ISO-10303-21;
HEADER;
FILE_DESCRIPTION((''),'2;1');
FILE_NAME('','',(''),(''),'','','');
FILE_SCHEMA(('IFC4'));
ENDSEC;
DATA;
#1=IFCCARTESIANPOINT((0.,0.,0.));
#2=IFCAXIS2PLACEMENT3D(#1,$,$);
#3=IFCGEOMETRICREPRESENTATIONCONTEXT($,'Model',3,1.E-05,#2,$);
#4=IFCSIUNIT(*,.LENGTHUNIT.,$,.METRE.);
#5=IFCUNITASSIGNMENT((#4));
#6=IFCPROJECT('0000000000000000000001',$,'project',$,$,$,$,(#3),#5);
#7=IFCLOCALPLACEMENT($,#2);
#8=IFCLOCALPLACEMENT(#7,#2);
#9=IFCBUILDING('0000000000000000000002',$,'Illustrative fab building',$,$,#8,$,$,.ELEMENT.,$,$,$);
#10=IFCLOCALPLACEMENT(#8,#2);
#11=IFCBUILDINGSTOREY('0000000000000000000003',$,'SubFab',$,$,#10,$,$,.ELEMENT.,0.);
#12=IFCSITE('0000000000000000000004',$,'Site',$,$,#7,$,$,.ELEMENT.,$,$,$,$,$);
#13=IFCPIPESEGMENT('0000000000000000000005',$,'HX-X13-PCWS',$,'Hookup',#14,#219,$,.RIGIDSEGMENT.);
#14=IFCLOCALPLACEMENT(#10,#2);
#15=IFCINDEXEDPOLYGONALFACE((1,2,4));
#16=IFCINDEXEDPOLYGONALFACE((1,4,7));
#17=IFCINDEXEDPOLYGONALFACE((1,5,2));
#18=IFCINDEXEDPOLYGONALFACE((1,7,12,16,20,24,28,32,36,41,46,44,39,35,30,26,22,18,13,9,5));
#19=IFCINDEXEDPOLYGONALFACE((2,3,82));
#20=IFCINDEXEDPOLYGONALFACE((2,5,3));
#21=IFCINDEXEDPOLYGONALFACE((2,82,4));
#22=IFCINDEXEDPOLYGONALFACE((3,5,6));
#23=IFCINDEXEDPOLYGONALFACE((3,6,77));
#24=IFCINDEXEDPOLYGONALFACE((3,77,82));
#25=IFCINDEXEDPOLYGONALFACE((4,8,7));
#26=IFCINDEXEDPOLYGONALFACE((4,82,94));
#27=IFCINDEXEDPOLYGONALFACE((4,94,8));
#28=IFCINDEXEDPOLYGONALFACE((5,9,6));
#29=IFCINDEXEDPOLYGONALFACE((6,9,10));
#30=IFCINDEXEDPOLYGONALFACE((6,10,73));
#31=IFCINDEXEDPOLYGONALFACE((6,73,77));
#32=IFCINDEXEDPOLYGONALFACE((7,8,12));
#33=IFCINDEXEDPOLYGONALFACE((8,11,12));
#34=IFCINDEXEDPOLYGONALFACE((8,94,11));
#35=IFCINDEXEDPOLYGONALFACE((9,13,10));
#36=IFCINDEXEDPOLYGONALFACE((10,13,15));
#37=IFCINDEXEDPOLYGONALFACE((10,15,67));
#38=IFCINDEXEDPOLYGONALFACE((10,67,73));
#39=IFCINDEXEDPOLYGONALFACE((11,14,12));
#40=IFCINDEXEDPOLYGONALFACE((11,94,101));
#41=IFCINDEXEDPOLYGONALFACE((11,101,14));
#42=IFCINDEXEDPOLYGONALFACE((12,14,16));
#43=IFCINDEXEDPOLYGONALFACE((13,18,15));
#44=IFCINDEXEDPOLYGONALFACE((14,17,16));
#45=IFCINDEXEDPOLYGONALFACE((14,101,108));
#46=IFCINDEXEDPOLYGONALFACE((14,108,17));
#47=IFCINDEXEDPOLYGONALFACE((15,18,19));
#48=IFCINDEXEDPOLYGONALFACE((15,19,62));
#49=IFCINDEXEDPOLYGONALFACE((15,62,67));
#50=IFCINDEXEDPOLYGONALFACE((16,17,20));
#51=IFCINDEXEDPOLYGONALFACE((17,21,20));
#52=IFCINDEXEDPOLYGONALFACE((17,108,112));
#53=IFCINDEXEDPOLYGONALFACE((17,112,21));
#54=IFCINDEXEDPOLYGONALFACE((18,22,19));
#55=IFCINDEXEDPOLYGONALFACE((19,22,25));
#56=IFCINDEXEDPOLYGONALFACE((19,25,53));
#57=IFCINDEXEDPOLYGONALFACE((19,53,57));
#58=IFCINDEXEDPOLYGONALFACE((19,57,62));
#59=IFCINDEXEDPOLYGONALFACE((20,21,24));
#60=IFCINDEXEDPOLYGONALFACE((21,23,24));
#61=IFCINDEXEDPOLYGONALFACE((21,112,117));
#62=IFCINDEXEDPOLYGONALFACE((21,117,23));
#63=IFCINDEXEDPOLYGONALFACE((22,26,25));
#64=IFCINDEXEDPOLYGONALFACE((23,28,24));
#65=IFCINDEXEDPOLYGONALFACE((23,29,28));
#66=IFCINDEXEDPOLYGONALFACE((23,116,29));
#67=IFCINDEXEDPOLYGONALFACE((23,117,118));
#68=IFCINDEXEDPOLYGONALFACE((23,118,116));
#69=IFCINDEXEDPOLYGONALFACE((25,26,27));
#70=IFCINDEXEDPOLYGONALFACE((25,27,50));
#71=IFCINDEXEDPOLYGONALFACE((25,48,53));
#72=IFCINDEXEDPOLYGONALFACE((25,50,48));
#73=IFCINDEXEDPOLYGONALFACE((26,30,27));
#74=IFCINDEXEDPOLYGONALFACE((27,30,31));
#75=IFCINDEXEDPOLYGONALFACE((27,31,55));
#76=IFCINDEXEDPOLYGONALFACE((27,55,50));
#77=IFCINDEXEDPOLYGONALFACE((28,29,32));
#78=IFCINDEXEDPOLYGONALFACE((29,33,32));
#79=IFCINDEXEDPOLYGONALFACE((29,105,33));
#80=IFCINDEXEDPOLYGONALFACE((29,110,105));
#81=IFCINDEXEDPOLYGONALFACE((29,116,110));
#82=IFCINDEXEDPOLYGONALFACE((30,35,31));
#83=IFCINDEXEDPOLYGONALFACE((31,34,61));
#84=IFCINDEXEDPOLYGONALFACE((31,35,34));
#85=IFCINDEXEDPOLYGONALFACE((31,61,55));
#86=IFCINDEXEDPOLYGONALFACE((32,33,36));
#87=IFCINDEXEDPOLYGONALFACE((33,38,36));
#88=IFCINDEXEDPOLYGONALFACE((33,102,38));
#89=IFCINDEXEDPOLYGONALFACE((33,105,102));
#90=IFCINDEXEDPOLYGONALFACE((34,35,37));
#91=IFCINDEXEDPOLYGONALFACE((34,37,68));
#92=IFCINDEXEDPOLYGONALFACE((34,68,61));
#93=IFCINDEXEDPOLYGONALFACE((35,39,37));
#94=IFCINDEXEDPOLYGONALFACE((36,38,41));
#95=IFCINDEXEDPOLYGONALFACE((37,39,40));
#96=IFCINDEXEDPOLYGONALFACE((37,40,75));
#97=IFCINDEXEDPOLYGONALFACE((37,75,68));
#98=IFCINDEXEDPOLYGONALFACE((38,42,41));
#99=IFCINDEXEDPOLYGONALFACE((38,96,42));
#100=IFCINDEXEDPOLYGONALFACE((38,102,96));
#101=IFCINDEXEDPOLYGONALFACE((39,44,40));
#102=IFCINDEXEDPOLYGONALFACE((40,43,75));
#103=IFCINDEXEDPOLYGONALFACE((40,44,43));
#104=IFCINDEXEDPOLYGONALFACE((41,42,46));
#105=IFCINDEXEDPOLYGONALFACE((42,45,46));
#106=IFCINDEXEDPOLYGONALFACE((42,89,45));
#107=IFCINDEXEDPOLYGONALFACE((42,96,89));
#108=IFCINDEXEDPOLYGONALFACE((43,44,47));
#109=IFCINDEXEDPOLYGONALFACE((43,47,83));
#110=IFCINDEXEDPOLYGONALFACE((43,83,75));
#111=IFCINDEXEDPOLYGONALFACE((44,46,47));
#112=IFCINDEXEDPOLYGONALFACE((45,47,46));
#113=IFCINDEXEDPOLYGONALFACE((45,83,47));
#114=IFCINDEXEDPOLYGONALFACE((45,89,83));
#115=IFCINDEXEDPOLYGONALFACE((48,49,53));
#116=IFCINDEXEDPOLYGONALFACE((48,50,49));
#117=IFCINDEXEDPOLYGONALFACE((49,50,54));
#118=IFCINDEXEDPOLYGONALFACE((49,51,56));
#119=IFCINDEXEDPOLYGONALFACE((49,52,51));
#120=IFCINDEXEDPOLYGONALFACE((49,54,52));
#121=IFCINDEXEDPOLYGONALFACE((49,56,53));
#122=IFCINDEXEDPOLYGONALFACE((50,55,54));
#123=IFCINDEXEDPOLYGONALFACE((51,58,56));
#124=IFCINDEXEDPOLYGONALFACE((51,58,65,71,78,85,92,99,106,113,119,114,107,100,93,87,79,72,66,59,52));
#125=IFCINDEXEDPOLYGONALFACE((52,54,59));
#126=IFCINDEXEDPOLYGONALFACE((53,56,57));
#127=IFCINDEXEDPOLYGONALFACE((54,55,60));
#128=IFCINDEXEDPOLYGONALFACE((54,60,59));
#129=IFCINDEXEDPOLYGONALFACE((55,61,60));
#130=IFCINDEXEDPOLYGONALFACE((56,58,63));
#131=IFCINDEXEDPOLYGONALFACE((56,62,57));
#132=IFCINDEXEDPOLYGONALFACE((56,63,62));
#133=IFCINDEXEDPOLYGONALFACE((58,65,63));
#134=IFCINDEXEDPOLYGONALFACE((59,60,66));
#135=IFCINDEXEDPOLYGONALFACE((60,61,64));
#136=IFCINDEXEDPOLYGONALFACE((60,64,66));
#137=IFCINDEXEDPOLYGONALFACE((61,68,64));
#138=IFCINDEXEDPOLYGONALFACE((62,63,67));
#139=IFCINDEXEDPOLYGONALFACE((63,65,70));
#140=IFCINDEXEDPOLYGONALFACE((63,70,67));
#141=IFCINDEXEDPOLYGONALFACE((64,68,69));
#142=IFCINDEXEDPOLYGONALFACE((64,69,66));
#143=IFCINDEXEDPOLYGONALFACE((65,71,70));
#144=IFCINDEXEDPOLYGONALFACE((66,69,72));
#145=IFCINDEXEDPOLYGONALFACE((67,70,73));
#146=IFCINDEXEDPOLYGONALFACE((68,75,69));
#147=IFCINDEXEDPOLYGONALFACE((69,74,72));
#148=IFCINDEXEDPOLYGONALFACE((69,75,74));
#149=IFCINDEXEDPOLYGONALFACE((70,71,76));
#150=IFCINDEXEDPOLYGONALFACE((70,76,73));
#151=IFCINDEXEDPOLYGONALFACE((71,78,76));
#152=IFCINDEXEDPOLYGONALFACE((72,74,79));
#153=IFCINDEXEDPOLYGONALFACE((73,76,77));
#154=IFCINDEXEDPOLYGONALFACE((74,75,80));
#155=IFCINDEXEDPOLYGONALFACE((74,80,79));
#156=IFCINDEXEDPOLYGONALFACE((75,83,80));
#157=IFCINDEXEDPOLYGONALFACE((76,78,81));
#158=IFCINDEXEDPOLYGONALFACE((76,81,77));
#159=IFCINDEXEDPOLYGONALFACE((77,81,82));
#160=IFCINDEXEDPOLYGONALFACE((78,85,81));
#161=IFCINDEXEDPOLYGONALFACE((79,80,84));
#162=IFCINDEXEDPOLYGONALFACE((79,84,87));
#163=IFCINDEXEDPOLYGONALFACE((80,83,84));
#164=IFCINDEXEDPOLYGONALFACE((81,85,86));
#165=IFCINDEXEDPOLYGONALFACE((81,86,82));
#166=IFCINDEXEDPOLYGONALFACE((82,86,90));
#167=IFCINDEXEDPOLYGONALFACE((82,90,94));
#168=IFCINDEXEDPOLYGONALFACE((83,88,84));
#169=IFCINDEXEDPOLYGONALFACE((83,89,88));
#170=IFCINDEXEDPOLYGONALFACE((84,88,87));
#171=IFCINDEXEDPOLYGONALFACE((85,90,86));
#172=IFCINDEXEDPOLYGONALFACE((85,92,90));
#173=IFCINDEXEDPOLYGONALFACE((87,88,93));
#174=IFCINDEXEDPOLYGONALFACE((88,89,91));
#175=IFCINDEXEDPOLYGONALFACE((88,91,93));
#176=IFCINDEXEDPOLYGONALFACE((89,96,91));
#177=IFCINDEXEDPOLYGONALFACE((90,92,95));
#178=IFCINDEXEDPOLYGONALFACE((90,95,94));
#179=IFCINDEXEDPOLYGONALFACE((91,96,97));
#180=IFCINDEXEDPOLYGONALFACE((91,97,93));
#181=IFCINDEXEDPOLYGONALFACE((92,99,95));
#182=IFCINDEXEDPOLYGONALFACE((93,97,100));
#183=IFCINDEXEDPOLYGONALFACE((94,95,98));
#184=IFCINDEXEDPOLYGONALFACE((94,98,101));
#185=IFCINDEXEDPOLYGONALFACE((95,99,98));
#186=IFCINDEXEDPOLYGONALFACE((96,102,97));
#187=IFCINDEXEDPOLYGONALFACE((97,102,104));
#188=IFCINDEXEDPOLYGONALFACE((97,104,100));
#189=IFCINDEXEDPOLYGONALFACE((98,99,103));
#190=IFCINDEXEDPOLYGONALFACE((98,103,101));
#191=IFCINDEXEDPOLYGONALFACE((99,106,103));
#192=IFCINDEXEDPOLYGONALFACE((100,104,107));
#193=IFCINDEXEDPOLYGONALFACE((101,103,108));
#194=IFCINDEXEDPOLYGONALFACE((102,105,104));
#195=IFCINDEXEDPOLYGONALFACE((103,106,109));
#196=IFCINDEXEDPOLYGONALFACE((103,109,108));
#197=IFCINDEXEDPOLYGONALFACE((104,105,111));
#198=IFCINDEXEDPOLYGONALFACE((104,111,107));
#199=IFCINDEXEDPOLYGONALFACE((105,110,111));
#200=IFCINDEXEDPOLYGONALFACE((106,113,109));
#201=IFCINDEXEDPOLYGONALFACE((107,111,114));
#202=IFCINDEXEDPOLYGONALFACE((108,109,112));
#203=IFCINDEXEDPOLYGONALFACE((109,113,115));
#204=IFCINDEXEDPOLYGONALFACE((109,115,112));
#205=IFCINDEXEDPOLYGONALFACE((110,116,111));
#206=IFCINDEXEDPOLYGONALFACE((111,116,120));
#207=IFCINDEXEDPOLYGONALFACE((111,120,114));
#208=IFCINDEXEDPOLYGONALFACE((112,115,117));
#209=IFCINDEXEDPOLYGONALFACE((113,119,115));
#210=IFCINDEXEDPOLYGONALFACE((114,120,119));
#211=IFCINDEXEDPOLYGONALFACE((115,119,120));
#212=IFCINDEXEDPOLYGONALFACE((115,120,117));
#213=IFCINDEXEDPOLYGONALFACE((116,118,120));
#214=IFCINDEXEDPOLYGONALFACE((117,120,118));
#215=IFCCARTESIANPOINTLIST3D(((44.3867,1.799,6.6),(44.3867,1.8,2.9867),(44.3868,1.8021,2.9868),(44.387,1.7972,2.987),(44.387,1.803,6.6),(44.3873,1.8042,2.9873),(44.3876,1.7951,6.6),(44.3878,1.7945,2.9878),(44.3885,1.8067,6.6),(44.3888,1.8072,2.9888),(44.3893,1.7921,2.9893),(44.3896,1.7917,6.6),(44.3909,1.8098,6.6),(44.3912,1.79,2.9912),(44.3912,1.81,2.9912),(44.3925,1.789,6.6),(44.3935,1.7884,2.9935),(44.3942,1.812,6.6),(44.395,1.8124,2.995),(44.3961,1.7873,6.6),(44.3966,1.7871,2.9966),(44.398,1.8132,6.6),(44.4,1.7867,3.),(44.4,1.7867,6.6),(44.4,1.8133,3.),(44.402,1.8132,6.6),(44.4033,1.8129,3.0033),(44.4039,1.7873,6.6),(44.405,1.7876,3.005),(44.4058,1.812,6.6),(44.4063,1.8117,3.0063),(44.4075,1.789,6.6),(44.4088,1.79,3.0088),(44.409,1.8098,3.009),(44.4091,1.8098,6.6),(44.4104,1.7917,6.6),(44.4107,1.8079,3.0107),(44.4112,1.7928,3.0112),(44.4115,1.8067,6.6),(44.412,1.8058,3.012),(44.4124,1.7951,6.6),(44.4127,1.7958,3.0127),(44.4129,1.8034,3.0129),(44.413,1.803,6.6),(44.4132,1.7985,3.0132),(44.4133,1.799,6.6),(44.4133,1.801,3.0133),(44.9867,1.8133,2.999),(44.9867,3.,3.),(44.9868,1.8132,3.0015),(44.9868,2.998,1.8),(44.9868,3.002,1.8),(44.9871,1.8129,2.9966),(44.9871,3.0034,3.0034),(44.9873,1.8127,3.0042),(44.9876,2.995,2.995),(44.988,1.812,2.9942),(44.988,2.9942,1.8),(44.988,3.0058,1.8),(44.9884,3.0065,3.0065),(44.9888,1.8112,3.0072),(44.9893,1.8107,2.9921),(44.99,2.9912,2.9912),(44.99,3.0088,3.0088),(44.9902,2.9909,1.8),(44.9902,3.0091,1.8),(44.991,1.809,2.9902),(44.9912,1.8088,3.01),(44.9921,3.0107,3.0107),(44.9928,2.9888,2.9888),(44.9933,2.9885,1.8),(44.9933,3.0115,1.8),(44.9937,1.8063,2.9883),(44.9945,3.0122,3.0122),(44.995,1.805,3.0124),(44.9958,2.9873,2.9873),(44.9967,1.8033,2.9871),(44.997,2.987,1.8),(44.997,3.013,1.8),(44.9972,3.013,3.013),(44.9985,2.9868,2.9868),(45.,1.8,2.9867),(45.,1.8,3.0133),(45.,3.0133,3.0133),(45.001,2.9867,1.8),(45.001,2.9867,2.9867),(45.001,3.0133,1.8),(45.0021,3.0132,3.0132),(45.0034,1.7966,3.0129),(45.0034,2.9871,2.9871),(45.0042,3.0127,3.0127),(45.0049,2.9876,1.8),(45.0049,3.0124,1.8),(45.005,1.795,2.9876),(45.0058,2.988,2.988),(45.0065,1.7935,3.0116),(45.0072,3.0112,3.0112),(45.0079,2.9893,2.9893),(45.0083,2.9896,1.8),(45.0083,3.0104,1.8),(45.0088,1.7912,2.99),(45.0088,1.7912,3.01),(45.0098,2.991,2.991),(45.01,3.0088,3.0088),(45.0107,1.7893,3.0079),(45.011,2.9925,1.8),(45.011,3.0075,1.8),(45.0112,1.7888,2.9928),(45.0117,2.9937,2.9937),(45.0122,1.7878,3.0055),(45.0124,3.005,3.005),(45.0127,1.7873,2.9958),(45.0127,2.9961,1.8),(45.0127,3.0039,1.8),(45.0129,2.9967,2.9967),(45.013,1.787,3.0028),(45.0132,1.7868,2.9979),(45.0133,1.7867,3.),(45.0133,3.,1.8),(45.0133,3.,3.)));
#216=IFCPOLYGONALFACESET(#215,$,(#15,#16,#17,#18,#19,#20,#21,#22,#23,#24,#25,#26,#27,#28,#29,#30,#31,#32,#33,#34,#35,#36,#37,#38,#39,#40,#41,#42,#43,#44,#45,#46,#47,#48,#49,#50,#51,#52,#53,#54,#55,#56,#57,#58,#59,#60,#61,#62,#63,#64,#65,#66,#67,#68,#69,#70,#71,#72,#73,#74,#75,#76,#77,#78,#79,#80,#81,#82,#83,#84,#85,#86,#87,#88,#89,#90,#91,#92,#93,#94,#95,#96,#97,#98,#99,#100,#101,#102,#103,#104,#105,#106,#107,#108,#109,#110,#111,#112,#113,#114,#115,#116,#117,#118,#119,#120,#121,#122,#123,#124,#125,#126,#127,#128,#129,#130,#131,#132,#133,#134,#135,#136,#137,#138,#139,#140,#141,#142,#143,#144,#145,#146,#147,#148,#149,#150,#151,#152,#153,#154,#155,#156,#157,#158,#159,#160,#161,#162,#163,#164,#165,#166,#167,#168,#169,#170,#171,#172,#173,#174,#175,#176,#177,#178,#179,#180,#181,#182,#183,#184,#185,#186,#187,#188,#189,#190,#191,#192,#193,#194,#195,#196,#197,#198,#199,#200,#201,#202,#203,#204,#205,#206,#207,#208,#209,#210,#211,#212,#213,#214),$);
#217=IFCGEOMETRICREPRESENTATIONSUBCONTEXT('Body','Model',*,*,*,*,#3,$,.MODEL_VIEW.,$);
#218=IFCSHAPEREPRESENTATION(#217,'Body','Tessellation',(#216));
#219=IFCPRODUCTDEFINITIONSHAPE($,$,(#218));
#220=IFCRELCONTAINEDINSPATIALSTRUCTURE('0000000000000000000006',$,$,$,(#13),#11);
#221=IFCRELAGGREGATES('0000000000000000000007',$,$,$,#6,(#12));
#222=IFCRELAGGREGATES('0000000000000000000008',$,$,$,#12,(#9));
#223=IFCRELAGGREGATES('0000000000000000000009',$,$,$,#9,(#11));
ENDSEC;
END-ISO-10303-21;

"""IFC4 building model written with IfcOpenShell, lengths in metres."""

from ifc_helpers import new_model, entity, si_unit, origin, place, context, subcontext, project, spatial, element, save


model = new_model("IFC4")

# Units and contexts
model_context = context("Model", 3, precision=1e-05, world=origin())
body_context = subcontext(model_context, "Body", "Model", "MODEL_VIEW")
ifc_project = project(units=[si_unit("LENGTHUNIT", "METRE")], contexts=[model_context])

# Site, building, storey
site_placement = place(None, origin())
site = spatial("IfcSite", under=ifc_project, at=site_placement, Name="Site", CompositionType="ELEMENT")
building_placement = place(site_placement, origin())
building = spatial("IfcBuilding", under=site, at=building_placement, Name="Illustrative fab building", CompositionType="ELEMENT")
storey_placement = place(building_placement, origin())
storey = spatial("IfcBuildingStorey", under=building, at=storey_placement, Name="SubFab", CompositionType="ELEMENT", Elevation=0.0)

# Pipe segment
pipe_segment_1_placement = place(storey_placement, origin())
element("IfcPipeSegment", 1, at=pipe_segment_1_placement, inside=storey, Name="HX-X13-PCWS", ObjectType="Hookup", PredefinedType="RIGIDSEGMENT", context=body_context, shape_type="AdvancedSweptSolid", body=[
    entity("IfcSweptDiskSolid", entity("IfcPolyline", [entity("IfcCartesianPoint", [45.0, 3.0, 1.8]), entity("IfcCartesianPoint", [45.0, 3.0, 3.0]), entity("IfcCartesianPoint", [45.0, 1.8, 3.0]), entity("IfcCartesianPoint", [44.4, 1.8, 3.0]), entity("IfcCartesianPoint", [44.4, 1.8, 6.6])]), 0.0133),
])

save(model, "model.ifc")
